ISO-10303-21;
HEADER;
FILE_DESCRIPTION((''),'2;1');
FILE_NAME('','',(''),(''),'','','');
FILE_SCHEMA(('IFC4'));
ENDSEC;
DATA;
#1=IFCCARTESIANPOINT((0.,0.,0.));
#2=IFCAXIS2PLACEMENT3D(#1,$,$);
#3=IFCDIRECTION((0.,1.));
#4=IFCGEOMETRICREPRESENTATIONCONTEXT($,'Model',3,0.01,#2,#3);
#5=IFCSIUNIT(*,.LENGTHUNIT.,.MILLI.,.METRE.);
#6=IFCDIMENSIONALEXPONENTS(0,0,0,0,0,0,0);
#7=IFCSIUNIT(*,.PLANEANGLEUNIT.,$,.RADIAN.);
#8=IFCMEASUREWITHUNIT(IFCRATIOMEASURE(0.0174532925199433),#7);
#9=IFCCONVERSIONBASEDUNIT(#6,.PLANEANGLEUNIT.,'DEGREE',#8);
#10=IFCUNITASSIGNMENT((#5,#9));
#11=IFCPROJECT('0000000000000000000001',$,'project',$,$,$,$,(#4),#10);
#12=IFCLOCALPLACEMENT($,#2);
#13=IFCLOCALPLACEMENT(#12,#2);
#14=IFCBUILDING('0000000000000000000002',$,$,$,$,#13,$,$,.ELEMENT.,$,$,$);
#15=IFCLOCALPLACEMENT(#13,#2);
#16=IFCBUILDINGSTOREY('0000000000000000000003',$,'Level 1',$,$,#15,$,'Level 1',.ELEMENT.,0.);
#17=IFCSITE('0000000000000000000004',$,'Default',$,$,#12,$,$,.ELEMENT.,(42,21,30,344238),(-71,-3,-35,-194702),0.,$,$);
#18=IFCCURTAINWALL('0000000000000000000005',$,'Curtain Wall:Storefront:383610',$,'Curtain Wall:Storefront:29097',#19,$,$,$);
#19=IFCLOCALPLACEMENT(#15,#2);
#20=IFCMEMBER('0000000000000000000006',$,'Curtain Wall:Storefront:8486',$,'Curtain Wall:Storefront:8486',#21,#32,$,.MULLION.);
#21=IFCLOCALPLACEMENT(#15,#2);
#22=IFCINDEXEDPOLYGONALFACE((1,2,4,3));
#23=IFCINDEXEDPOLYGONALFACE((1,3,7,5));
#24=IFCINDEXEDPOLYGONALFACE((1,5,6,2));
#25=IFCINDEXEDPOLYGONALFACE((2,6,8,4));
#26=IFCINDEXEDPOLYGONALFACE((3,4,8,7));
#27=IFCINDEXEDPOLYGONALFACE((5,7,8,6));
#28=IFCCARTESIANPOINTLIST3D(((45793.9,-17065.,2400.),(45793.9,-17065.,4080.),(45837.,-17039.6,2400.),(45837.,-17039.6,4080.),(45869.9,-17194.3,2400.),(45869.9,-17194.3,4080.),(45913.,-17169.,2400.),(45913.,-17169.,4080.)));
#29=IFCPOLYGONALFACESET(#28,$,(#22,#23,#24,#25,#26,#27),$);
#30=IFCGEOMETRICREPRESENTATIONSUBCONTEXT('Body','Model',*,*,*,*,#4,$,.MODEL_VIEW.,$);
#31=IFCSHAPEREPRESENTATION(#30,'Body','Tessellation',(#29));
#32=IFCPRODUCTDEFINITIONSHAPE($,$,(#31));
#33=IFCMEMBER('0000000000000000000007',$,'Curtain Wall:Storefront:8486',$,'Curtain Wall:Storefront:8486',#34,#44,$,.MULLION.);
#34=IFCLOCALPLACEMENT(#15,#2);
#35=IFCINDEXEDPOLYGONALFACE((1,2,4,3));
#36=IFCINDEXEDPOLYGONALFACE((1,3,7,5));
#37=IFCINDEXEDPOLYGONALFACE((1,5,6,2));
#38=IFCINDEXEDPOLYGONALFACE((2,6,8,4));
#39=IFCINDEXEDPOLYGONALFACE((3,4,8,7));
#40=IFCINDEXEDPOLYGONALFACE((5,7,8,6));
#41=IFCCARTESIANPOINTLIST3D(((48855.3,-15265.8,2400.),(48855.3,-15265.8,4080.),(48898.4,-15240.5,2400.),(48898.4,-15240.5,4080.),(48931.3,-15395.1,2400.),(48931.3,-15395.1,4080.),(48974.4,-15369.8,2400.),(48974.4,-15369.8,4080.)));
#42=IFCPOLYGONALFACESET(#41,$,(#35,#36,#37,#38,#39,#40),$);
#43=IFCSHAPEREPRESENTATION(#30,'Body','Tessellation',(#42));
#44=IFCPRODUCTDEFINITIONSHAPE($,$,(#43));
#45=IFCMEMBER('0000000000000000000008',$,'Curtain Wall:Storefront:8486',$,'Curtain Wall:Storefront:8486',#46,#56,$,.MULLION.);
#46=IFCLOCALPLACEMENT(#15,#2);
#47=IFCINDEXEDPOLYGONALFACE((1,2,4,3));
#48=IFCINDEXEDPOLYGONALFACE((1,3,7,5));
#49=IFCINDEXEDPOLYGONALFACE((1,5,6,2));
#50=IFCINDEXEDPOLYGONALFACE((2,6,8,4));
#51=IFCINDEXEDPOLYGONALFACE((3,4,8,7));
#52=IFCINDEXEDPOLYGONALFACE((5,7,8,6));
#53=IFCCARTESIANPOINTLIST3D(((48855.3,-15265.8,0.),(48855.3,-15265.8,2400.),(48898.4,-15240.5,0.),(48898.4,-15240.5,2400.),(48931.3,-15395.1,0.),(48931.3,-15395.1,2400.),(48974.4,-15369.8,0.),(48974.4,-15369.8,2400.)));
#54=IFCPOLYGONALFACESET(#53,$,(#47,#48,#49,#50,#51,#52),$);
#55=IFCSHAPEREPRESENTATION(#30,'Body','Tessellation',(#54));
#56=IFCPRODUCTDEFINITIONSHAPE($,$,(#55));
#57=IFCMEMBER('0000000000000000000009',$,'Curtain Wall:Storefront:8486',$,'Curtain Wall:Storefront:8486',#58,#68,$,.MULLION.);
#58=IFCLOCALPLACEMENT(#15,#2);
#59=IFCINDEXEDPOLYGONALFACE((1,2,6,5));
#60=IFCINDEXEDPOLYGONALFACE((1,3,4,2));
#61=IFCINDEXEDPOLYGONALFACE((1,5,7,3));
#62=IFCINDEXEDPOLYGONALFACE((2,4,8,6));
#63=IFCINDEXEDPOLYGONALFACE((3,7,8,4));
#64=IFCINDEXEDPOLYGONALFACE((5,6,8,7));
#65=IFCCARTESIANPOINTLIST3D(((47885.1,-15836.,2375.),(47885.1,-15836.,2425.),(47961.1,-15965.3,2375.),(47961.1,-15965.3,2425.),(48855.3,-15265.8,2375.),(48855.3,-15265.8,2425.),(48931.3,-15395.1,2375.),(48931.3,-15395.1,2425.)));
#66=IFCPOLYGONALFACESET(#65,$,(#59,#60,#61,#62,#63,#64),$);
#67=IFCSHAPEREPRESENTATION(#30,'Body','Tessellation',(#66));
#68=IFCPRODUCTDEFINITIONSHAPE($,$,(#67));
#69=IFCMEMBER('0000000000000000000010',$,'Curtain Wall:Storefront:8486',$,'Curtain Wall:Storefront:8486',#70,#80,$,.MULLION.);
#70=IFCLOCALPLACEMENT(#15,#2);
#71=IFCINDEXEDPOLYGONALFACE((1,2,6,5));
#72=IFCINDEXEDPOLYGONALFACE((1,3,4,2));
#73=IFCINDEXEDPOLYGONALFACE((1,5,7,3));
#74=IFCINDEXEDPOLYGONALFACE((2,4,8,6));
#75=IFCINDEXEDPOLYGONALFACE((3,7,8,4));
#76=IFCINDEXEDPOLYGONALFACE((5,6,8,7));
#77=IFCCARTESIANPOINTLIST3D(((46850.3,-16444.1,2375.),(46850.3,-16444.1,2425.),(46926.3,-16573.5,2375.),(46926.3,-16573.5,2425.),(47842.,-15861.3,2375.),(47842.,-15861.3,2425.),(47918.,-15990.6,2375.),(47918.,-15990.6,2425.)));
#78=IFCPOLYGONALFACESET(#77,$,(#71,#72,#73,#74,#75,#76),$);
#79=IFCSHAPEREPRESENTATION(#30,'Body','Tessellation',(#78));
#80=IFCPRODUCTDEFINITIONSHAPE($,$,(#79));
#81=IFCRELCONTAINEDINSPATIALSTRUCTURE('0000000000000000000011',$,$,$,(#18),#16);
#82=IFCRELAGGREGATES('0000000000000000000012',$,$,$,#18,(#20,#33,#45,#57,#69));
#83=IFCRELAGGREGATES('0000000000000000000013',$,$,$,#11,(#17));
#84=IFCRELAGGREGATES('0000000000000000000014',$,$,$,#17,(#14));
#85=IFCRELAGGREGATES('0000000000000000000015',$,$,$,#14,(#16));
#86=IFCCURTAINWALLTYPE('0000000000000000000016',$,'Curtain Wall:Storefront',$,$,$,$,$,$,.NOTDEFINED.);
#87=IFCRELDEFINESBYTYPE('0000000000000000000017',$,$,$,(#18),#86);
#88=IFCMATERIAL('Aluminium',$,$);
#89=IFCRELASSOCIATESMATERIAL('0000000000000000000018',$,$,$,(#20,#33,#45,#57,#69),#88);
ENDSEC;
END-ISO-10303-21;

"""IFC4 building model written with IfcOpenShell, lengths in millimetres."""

from ifc_helpers import new_model, entity, si_unit, converted_unit, direction, frame, frame_2d, origin, origin_2d_with_axis, place, context, subcontext, project, spatial, rectangle, extrude, material, type_object, element, aggregate, save


model = new_model("IFC4")

# Units and contexts
model_context = context("Model", 3, precision=0.01, world=origin(), true_north=direction((0.0, 1.0)))
body_context = subcontext(model_context, "Body", "Model", "MODEL_VIEW")
ifc_project = project(units=[si_unit("LENGTHUNIT", "METRE", prefix="MILLI"), converted_unit("PLANEANGLEUNIT", "DEGREE", entity("IfcRatioMeasure", 0.0174532925199433), si_unit("PLANEANGLEUNIT", "RADIAN"), dimensions=[0, 0, 0, 0, 0, 0, 0])], contexts=[model_context])

# Site, building, storey
site_placement = place(None, origin())
site = spatial("IfcSite", under=ifc_project, at=site_placement, Name="Default", CompositionType="ELEMENT", RefLatitude=(42, 21, 30, 344238), RefLongitude=(-71, -3, -35, -194702), RefElevation=0.0)
building_placement = place(site_placement, origin())
building = spatial("IfcBuilding", under=site, at=building_placement, CompositionType="ELEMENT")
storey_placement = place(building_placement, origin())
storey = spatial("IfcBuildingStorey", under=building, at=storey_placement, Name="Level 1", LongName="Level 1", CompositionType="ELEMENT", Elevation=0.0)

# Curtain wall, members
curtain_wall_type = type_object("IfcCurtainWallType", Name="Curtain Wall:Storefront", PredefinedType="NOTDEFINED")
ifc_material = material(Name="Aluminium")
curtain_wall_1_placement = place(storey_placement, origin())
curtain_wall_1 = element("IfcCurtainWall", 1, at=curtain_wall_1_placement, inside=storey, type_object=curtain_wall_type, Name="Curtain Wall:Storefront:383610", ObjectType="Curtain Wall:Storefront:29097")
member_1_placement = place(curtain_wall_1_placement, origin())
member_1 = element("IfcMember", 2, at=member_1_placement, material=ifc_material, Name="Curtain Wall:Storefront:8486", ObjectType="Curtain Wall:Storefront:8486", PredefinedType="MULLION", context=body_context, shape_type="SweptSolid", body=[
    extrude(rectangle(XDim=50.0, YDim=150.0, at=origin_2d_with_axis()), frame((45853.4, -17117.0, 2400.0), z_axis=(0.0, 0.0, 1.0), x_axis=(0.862143, 0.506665, 0.0)), (0.0, 0.0, 1.0), 1680.0),
])
member_2_placement = place(curtain_wall_1_placement, origin())
member_2 = element("IfcMember", 3, at=member_2_placement, material=ifc_material, Name="Curtain Wall:Storefront:8486", ObjectType="Curtain Wall:Storefront:8486", PredefinedType="MULLION", context=body_context, shape_type="SweptSolid", body=[
    extrude(rectangle(XDim=50.0, YDim=150.0, at=frame_2d((0.0, 0.0), x_axis=(1.0, 0.0))), frame((48914.9, -15317.8, 4080.0), z_axis=(0.0, 0.0, -1.0), x_axis=(0.862143, 0.506665, 0.0)), (0.0, 0.0, 1.0), 1680.0),
])
member_3_placement = place(curtain_wall_1_placement, origin())
member_3 = element("IfcMember", 4, at=member_3_placement, material=ifc_material, Name="Curtain Wall:Storefront:8486", ObjectType="Curtain Wall:Storefront:8486", PredefinedType="MULLION", context=body_context, shape_type="SweptSolid", body=[
    extrude(rectangle(XDim=50.0, YDim=150.0, at=frame_2d((0.0, 0.0), x_axis=(1.0, 0.0))), frame((48914.9, -15317.8, 2400.0), z_axis=(0.0, 0.0, -1.0), x_axis=(0.862143, 0.506665, 0.0)), (0.0, 0.0, 1.0), 2400.0),
])
member_4_placement = place(curtain_wall_1_placement, origin())
member_4 = element("IfcMember", 5, at=member_4_placement, material=ifc_material, Name="Curtain Wall:Storefront:8486", ObjectType="Curtain Wall:Storefront:8486", PredefinedType="MULLION", context=body_context, shape_type="SweptSolid", body=[
    extrude(rectangle(XDim=50.0, YDim=150.0, at=frame_2d((0.0, 0.0), x_axis=(1.0, 0.0))), frame((47923.1, -15900.6, 2400.0), z_axis=(0.862143, 0.506665, 0.0), x_axis=(0.0, 0.0, -1.0)), (0.0, 0.0, 1.0), 1125.3),
])
member_5_placement = place(curtain_wall_1_placement, origin())
member_5 = element("IfcMember", 6, at=member_5_placement, material=ifc_material, Name="Curtain Wall:Storefront:8486", ObjectType="Curtain Wall:Storefront:8486", PredefinedType="MULLION", context=body_context, shape_type="SweptSolid", body=[
    extrude(rectangle(XDim=50.0, YDim=150.0, at=frame_2d((0.0, 0.0), x_axis=(1.0, 0.0))), frame((46888.3, -16508.8, 2400.0), z_axis=(0.862143, 0.506665, 0.0), x_axis=(0.0, 0.0, -1.0)), (0.0, 0.0, 1.0), 1150.3),
])
aggregate(curtain_wall_1, [member_1, member_2, member_3, member_4, member_5])

save(model, "model.ifc")
